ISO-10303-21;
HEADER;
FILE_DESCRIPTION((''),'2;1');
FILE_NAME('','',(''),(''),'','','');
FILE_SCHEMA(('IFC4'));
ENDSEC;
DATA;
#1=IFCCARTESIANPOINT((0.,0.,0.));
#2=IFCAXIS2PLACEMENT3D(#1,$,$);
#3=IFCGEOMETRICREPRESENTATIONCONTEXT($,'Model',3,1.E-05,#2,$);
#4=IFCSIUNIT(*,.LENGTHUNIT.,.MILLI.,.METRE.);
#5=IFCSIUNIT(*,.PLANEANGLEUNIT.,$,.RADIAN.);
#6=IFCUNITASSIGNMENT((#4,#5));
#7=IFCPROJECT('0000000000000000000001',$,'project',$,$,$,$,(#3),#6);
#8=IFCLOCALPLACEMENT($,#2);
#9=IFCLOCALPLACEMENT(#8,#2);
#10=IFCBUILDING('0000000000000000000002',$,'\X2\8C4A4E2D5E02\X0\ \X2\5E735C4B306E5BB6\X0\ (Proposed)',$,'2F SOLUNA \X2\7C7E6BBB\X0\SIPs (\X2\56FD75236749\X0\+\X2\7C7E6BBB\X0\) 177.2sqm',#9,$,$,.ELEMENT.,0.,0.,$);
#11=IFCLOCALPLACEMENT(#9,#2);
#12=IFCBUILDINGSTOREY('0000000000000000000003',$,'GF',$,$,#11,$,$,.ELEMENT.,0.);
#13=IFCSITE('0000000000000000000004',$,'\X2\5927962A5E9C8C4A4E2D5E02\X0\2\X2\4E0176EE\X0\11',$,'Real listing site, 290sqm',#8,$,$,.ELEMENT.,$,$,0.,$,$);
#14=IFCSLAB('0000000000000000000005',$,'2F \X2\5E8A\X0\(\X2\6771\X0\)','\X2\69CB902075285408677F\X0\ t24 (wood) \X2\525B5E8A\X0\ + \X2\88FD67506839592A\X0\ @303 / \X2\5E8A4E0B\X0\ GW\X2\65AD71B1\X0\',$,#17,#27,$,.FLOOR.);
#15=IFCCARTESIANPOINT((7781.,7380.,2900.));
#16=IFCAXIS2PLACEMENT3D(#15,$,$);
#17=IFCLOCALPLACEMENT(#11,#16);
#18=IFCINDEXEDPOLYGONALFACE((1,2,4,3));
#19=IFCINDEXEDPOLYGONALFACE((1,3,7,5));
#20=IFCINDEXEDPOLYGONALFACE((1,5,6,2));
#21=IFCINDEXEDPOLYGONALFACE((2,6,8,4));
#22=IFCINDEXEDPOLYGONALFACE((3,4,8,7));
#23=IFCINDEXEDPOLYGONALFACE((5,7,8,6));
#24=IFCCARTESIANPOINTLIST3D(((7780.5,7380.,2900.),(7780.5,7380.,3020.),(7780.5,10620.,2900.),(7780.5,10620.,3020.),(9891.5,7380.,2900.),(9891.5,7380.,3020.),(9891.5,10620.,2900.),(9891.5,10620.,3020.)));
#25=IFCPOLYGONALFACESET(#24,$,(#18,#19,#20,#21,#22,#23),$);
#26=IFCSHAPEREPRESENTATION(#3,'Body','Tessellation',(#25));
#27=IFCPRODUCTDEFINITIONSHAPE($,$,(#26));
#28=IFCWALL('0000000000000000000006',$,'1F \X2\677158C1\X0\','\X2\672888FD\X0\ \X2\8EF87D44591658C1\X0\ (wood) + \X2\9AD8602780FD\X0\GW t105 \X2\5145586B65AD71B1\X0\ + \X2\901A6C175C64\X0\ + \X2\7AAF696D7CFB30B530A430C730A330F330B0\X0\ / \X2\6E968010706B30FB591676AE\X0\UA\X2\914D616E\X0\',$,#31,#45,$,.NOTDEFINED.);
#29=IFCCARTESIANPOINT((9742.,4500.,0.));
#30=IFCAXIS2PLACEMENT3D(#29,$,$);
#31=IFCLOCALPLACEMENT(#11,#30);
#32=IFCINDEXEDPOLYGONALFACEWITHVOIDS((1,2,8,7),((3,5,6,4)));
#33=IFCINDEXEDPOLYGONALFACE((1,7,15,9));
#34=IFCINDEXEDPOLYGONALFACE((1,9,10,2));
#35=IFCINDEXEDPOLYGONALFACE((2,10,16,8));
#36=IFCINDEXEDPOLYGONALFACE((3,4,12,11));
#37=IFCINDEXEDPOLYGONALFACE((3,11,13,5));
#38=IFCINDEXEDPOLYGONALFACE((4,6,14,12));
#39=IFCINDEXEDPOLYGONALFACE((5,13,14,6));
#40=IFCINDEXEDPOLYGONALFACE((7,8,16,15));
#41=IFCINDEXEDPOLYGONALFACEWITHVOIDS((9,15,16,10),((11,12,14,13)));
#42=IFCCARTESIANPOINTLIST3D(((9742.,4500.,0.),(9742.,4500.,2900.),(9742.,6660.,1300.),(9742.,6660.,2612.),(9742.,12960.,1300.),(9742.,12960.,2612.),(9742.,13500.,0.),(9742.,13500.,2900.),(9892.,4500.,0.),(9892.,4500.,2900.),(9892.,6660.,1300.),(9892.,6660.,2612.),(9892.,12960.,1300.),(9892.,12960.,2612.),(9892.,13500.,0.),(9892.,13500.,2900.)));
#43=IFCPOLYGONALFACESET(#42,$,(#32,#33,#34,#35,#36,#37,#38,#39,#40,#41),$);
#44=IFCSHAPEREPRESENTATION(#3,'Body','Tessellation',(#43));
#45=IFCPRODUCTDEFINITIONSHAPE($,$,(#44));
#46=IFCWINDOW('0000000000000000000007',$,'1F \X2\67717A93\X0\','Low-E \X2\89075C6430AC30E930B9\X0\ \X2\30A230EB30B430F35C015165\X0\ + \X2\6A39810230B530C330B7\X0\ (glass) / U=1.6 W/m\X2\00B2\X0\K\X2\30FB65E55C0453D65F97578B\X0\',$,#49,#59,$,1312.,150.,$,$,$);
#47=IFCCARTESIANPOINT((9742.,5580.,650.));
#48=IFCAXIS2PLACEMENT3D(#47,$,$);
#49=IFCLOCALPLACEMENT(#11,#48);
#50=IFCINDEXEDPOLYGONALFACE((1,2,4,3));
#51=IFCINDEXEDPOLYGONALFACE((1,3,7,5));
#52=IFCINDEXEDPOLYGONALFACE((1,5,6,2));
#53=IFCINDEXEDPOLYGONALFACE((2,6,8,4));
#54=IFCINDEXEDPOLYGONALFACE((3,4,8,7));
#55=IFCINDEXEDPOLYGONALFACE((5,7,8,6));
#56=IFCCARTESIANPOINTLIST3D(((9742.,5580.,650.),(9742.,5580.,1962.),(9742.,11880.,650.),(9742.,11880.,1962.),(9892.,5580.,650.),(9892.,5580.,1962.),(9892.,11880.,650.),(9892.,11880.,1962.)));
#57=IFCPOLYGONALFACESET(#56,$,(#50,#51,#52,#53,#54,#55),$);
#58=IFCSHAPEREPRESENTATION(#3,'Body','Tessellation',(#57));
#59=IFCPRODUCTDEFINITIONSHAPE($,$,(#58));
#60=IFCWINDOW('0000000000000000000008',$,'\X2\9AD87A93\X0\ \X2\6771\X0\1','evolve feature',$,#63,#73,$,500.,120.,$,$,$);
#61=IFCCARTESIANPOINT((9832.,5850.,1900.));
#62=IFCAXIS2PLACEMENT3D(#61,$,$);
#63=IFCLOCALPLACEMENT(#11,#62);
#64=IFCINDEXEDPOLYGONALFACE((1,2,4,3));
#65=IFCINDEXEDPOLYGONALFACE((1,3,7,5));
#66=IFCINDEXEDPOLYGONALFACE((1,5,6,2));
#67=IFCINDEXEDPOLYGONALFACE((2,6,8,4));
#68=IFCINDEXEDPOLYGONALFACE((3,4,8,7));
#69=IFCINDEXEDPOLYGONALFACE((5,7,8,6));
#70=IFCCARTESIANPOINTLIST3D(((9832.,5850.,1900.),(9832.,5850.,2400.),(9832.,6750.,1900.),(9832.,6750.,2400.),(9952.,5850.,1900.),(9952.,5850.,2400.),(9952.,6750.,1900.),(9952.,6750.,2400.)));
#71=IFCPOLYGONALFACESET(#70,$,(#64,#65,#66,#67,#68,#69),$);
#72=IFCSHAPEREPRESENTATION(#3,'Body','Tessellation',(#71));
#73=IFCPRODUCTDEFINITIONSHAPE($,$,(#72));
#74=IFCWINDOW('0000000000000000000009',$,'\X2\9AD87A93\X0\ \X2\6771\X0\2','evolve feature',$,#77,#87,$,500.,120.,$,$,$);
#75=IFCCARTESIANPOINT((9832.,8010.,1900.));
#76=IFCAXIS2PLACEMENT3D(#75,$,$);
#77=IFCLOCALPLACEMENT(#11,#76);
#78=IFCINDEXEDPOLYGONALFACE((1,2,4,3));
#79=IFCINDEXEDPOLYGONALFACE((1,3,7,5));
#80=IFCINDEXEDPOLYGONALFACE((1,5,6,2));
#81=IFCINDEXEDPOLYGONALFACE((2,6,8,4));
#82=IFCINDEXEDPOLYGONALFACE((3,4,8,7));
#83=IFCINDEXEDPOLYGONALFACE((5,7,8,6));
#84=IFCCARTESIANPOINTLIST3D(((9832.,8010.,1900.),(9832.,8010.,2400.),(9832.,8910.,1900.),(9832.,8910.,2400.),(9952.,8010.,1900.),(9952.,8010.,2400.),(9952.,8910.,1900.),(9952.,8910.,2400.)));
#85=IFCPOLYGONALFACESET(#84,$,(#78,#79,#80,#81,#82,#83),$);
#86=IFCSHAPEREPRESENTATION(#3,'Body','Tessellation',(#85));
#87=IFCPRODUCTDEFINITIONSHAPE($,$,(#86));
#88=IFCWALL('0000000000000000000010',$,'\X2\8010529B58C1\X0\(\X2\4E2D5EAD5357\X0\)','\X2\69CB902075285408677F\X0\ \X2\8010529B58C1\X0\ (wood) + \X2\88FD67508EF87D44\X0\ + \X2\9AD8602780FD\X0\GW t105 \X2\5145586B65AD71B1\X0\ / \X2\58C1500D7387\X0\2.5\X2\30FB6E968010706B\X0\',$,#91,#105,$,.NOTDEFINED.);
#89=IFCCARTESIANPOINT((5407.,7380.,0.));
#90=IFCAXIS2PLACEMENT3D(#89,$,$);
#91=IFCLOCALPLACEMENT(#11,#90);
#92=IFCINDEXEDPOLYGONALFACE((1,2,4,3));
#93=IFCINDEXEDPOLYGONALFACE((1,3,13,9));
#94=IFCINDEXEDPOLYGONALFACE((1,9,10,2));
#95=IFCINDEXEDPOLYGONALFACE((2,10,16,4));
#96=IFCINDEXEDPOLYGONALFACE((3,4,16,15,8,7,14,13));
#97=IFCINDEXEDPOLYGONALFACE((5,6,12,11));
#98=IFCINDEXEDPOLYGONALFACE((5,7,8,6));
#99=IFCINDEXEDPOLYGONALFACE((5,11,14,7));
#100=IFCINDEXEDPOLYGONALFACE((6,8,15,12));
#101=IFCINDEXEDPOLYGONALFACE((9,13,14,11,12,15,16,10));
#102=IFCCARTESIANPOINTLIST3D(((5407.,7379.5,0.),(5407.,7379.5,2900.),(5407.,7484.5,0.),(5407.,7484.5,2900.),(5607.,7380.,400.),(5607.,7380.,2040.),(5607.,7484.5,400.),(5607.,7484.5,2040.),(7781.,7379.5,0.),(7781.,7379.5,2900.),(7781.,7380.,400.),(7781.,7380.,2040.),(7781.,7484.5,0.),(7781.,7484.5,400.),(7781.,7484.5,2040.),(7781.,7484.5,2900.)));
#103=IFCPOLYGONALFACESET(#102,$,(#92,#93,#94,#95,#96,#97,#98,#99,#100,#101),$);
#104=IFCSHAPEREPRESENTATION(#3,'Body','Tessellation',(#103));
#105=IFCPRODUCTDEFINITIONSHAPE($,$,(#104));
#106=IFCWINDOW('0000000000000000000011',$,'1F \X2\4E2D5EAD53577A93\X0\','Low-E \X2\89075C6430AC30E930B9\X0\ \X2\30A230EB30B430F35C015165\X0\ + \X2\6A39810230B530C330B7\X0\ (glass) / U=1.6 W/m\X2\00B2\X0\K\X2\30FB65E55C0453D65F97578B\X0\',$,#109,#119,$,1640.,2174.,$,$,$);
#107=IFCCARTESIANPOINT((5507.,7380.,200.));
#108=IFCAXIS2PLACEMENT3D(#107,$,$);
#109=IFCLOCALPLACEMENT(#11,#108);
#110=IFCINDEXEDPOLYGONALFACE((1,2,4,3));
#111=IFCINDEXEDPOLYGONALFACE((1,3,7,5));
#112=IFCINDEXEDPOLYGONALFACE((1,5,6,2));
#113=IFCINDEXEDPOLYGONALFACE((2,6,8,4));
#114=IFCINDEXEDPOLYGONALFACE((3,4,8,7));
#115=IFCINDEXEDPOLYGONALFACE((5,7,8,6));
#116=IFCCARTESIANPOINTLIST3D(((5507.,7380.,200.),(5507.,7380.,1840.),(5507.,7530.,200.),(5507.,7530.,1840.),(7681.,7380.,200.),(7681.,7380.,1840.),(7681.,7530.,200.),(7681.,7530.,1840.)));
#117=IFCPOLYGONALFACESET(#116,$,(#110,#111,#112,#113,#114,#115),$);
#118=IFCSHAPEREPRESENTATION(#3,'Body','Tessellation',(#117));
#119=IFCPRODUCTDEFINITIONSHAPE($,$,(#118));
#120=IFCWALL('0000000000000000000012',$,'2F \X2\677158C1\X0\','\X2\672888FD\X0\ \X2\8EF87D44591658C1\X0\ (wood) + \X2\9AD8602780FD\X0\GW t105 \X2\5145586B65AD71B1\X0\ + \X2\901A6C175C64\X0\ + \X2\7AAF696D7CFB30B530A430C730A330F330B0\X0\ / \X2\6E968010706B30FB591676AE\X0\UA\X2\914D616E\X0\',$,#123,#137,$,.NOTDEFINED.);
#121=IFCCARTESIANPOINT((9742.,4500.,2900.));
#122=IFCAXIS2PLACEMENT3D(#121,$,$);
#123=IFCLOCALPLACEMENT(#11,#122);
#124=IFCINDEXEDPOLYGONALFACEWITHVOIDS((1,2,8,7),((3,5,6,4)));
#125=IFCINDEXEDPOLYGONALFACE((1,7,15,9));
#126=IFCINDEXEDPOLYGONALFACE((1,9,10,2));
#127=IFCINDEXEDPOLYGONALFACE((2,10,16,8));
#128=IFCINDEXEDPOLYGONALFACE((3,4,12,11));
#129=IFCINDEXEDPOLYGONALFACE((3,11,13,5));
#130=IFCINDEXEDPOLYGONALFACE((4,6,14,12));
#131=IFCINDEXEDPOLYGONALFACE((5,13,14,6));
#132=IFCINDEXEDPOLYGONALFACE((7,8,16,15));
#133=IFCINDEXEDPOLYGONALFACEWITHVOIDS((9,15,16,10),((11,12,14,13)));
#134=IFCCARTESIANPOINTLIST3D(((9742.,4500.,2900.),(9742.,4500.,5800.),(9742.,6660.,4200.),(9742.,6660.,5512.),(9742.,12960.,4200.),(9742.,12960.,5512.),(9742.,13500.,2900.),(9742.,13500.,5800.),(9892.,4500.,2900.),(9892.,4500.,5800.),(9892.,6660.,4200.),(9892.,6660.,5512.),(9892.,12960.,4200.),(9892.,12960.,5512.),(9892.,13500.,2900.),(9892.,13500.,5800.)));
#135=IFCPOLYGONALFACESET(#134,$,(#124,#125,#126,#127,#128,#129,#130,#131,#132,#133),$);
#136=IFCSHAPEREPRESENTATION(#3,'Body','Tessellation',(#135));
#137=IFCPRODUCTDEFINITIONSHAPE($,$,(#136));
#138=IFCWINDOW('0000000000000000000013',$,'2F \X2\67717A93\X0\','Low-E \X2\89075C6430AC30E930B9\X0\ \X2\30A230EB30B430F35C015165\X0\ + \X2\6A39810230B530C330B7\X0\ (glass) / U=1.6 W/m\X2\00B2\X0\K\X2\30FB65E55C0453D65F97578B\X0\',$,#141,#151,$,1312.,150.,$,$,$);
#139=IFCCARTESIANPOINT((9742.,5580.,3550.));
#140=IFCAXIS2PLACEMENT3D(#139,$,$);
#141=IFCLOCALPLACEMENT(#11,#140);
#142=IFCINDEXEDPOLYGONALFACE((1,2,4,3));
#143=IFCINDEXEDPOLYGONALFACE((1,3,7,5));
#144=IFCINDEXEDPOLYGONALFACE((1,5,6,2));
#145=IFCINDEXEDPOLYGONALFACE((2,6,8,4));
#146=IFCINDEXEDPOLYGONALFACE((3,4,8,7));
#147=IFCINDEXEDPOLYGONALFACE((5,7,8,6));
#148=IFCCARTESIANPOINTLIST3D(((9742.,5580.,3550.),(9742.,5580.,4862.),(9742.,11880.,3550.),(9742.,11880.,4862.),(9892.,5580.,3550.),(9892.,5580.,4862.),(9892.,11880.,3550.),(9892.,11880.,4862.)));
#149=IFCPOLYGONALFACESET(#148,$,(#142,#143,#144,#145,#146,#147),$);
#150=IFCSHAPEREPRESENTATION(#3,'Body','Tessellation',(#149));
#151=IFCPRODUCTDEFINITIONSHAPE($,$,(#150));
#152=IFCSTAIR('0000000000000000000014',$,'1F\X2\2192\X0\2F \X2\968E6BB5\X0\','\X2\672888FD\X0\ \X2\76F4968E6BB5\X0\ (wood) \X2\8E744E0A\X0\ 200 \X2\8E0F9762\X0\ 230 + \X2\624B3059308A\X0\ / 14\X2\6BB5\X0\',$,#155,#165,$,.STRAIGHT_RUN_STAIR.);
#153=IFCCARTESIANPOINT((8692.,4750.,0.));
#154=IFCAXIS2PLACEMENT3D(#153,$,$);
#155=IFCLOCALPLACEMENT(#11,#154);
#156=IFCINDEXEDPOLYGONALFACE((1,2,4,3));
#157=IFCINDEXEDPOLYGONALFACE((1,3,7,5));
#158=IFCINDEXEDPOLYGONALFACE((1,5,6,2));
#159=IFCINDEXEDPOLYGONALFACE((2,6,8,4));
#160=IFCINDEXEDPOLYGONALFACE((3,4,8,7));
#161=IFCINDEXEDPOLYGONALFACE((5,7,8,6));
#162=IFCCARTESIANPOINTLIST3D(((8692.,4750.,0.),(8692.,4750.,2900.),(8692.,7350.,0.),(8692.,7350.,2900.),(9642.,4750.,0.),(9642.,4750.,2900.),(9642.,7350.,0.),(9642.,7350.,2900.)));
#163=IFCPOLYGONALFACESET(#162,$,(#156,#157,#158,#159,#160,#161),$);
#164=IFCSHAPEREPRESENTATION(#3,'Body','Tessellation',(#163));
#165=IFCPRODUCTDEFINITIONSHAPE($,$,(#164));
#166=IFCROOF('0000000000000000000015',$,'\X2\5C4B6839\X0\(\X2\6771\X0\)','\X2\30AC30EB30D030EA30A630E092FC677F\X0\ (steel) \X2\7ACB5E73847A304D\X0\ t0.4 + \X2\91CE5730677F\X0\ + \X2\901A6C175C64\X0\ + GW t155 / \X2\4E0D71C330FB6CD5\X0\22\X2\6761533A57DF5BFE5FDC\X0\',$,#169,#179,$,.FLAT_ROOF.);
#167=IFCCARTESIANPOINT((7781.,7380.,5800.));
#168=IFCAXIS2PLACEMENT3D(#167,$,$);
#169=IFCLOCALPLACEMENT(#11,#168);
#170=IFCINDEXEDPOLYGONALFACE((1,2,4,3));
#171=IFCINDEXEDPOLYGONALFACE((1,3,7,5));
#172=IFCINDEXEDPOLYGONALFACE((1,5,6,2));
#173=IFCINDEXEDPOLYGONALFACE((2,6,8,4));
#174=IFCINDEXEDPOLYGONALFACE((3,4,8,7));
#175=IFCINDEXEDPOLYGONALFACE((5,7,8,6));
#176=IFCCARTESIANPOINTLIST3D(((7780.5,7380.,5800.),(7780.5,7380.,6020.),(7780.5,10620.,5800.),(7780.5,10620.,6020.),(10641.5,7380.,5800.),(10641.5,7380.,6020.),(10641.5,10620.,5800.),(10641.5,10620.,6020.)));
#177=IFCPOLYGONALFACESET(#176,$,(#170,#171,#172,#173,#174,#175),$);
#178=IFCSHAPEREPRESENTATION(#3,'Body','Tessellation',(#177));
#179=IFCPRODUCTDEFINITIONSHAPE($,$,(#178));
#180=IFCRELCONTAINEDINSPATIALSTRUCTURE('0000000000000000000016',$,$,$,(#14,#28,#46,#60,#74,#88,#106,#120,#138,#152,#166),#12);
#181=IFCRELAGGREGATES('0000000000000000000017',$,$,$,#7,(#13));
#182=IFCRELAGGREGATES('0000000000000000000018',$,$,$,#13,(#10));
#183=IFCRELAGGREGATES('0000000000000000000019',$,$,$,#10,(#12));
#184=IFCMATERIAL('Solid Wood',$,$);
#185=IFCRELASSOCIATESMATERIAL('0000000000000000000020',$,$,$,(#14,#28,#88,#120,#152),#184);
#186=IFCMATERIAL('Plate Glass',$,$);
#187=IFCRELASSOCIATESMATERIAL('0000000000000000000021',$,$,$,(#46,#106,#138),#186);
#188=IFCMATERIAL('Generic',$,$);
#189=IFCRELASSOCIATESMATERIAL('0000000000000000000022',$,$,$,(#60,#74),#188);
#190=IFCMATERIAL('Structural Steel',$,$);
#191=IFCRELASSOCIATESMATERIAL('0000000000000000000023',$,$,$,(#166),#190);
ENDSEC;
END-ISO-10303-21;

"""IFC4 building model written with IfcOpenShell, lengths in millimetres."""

from ifc_helpers import new_model, si_unit, frame, frame_2d, origin, place, context, project, spatial, rectangle, extrude, material, element, fill, save


model = new_model("IFC4")

# Units and contexts
model_context = context("Model", 3, precision=1e-05, world=origin())
ifc_project = project(units=[si_unit("LENGTHUNIT", "METRE", prefix="MILLI"), si_unit("PLANEANGLEUNIT", "RADIAN")], contexts=[model_context])

# Site, building, storey
site_placement = place(None, origin())
site = spatial("IfcSite", under=ifc_project, at=site_placement, Name="大阪府豊中市2丁目11", ObjectType="Real listing site, 290sqm", CompositionType="ELEMENT", RefElevation=0.0)
building_placement = place(site_placement, origin())
building = spatial("IfcBuilding", under=site, at=building_placement, Name="豊中市 平屋の家 (Proposed)", ObjectType="2F SOLUNA 籾殻SIPs (国産杉+籾殻) 177.2sqm", CompositionType="ELEMENT", ElevationOfRefHeight=0.0, ElevationOfTerrain=0.0)
storey_placement = place(building_placement, origin())
storey = spatial("IfcBuildingStorey", under=building, at=storey_placement, Name="GF", CompositionType="ELEMENT", Elevation=0.0)

# Slab
ifc_material_1 = material(Name="Solid Wood")
slab_1_placement = place(storey_placement, frame((7781.0, 7380.0, 2900.0)))
element("IfcSlab", 1, at=slab_1_placement, inside=storey, material=ifc_material_1, Name="2F 床(東)", Description="構造用合板 t24 (wood) 剛床 + 製材根太 @303 / 床下 GW断熱", PredefinedType="FLOOR", context=model_context, shape_type="SweptSolid", body=[
    extrude(rectangle(XDim=2111.0, YDim=3240.0, at=frame_2d((1055.0, 1620.0))), frame((7781.0, 7380.0, 2900.0)), (0.0, 0.0, 1.0), 120.0),
])

# Wall, openings, windows
wall_1_placement = place(storey_placement, frame((9742.0, 4500.0, 0.0)))
wall_1 = element("IfcWall", 2, at=wall_1_placement, inside=storey, material=ifc_material_1, Name="1F 東壁", Description="木製 軸組外壁 (wood) + 高性能GW t105 充填断熱 + 通気層 + 窯業系サイディング / 準耐火・外皮UA配慮", PredefinedType="NOTDEFINED", context=model_context, shape_type="SweptSolid", body=[
    extrude(rectangle(XDim=150.0, YDim=9000.0, at=frame_2d((75.0, 4500.0))), frame((9742.0, 4500.0, 0.0)), (0.0, 0.0, 1.0), 2900.0),
])
opening_1_placement = place(storey_placement, frame((9742.0, 5580.0, 650.0)))
opening_1 = element("IfcOpeningElement", 3, at=opening_1_placement, cuts=wall_1, PredefinedType="NOTDEFINED", context=model_context, shape_type="SweptSolid", body=[
    extrude(rectangle(XDim=150.0, YDim=6300.0, at=frame_2d((75.0, 3150.0))), frame((9742.0, 5580.0, 650.0)), (0.0, 0.0, 1.0), 1312.0),
])
opening_2_placement = place(storey_placement, frame((9832.0, 5850.0, 1900.0)))
opening_2 = element("IfcOpeningElement", 4, at=opening_2_placement, cuts=wall_1, PredefinedType="NOTDEFINED", context=model_context, shape_type="SweptSolid", body=[
    extrude(rectangle(XDim=120.0, YDim=900.0, at=frame_2d((60.0, 450.0))), frame((9832.0, 5850.0, 1900.0)), (0.0, 0.0, 1.0), 500.0),
])
opening_3_placement = place(storey_placement, frame((9832.0, 8010.0, 1900.0)))
opening_3 = element("IfcOpeningElement", 5, at=opening_3_placement, cuts=wall_1, PredefinedType="NOTDEFINED", context=model_context, shape_type="SweptSolid", body=[
    extrude(rectangle(XDim=120.0, YDim=900.0, at=frame_2d((60.0, 450.0))), frame((9832.0, 8010.0, 1900.0)), (0.0, 0.0, 1.0), 500.0),
])
ifc_material_2 = material(Name="Plate Glass")
window_1_placement = place(storey_placement, frame((9742.0, 5580.0, 650.0)))
window_1 = element("IfcWindow", 6, at=window_1_placement, inside=storey, material=ifc_material_2, Name="1F 東窓", Description="Low-E 複層ガラス アルゴン封入 + 樹脂サッシ (glass) / U=1.6 W/m²K・日射取得型", OverallHeight=1312.0, OverallWidth=150.0, context=model_context, shape_type="SweptSolid", body=[
    extrude(rectangle(XDim=150.0, YDim=6300.0, at=frame_2d((75.0, 3150.0))), frame((9742.0, 5580.0, 650.0)), (0.0, 0.0, 1.0), 1312.0),
])
fill(opening_1, window_1)
ifc_material_3 = material(Name="Generic")
window_2_placement = place(storey_placement, frame((9832.0, 5850.0, 1900.0)))
window_2 = element("IfcWindow", 7, at=window_2_placement, inside=storey, material=ifc_material_3, Name="高窓 東1", Description="evolve feature", OverallHeight=500.0, OverallWidth=120.0, context=model_context, shape_type="SweptSolid", body=[
    extrude(rectangle(XDim=120.0, YDim=900.0, at=frame_2d((60.0, 450.0))), frame((9832.0, 5850.0, 1900.0)), (0.0, 0.0, 1.0), 500.0),
])
fill(opening_2, window_2)
window_3_placement = place(storey_placement, frame((9832.0, 8010.0, 1900.0)))
window_3 = element("IfcWindow", 8, at=window_3_placement, inside=storey, material=ifc_material_3, Name="高窓 東2", Description="evolve feature", OverallHeight=500.0, OverallWidth=120.0, context=model_context, shape_type="SweptSolid", body=[
    extrude(rectangle(XDim=120.0, YDim=900.0, at=frame_2d((60.0, 450.0))), frame((9832.0, 8010.0, 1900.0)), (0.0, 0.0, 1.0), 500.0),
])
fill(opening_3, window_3)

# Wall, opening, window
wall_2_placement = place(storey_placement, frame((5407.0, 7380.0, 0.0)))
wall_2 = element("IfcWall", 9, at=wall_2_placement, inside=storey, material=ifc_material_1, Name="耐力壁(中庭南)", Description="構造用合板 耐力壁 (wood) + 製材軸組 + 高性能GW t105 充填断熱 / 壁倍率2.5・準耐火", PredefinedType="NOTDEFINED", context=model_context, shape_type="SweptSolid", body=[
    extrude(rectangle(XDim=2374.0, YDim=105.0, at=frame_2d((1187.0, 52.0))), frame((5407.0, 7380.0, 0.0)), (0.0, 0.0, 1.0), 2900.0),
])
opening_4_placement = place(storey_placement, frame((5507.0, 7380.0, 200.0)))
opening_4 = element("IfcOpeningElement", 10, at=opening_4_placement, cuts=wall_2, PredefinedType="NOTDEFINED", context=model_context, shape_type="SweptSolid", body=[
    extrude(rectangle(XDim=2174.0, YDim=150.0, at=frame_2d((1087.0, 75.0))), frame((5507.0, 7380.0, 200.0)), (0.0, 0.0, 1.0), 1640.0),
])
window_4_placement = place(storey_placement, frame((5507.0, 7380.0, 200.0)))
window_4 = element("IfcWindow", 11, at=window_4_placement, inside=storey, material=ifc_material_2, Name="1F 中庭南窓", Description="Low-E 複層ガラス アルゴン封入 + 樹脂サッシ (glass) / U=1.6 W/m²K・日射取得型", OverallHeight=1640.0, OverallWidth=2174.0, context=model_context, shape_type="SweptSolid", body=[
    extrude(rectangle(XDim=2174.0, YDim=150.0, at=frame_2d((1087.0, 75.0))), frame((5507.0, 7380.0, 200.0)), (0.0, 0.0, 1.0), 1640.0),
])
fill(opening_4, window_4)

# Wall, opening, window
wall_3_placement = place(storey_placement, frame((9742.0, 4500.0, 2900.0)))
wall_3 = element("IfcWall", 12, at=wall_3_placement, inside=storey, material=ifc_material_1, Name="2F 東壁", Description="木製 軸組外壁 (wood) + 高性能GW t105 充填断熱 + 通気層 + 窯業系サイディング / 準耐火・外皮UA配慮", PredefinedType="NOTDEFINED", context=model_context, shape_type="SweptSolid", body=[
    extrude(rectangle(XDim=150.0, YDim=9000.0, at=frame_2d((75.0, 4500.0))), frame((9742.0, 4500.0, 2900.0)), (0.0, 0.0, 1.0), 2900.0),
])
opening_5_placement = place(storey_placement, frame((9742.0, 5580.0, 3550.0)))
opening_5 = element("IfcOpeningElement", 13, at=opening_5_placement, cuts=wall_3, PredefinedType="NOTDEFINED", context=model_context, shape_type="SweptSolid", body=[
    extrude(rectangle(XDim=150.0, YDim=6300.0, at=frame_2d((75.0, 3150.0))), frame((9742.0, 5580.0, 3550.0)), (0.0, 0.0, 1.0), 1312.0),
])
window_5_placement = place(storey_placement, frame((9742.0, 5580.0, 3550.0)))
window_5 = element("IfcWindow", 14, at=window_5_placement, inside=storey, material=ifc_material_2, Name="2F 東窓", Description="Low-E 複層ガラス アルゴン封入 + 樹脂サッシ (glass) / U=1.6 W/m²K・日射取得型", OverallHeight=1312.0, OverallWidth=150.0, context=model_context, shape_type="SweptSolid", body=[
    extrude(rectangle(XDim=150.0, YDim=6300.0, at=frame_2d((75.0, 3150.0))), frame((9742.0, 5580.0, 3550.0)), (0.0, 0.0, 1.0), 1312.0),
])
fill(opening_5, window_5)

# Stair
stair_placement = place(storey_placement, frame((8692.0, 4750.0, 0.0)))
element("IfcStair", 15, at=stair_placement, inside=storey, material=ifc_material_1, Name="1F→2F 階段", Description="木製 直階段 (wood) 蹴上 200 踏面 230 + 手すり / 14段", PredefinedType="STRAIGHT_RUN_STAIR", context=model_context, shape_type="SweptSolid", body=[
    extrude(rectangle(XDim=950.0, YDim=2600.0, at=frame_2d((475.0, 1300.0))), frame((8692.0, 4750.0, 0.0)), (0.0, 0.0, 1.0), 2900.0),
])

# Roof
ifc_material_4 = material(Name="Structural Steel")
roof_placement = place(storey_placement, frame((7781.0, 7380.0, 5800.0)))
element("IfcRoof", 16, at=roof_placement, inside=storey, material=ifc_material_4, Name="屋根(東)", Description="ガルバリウム鋼板 (steel) 立平葺き t0.4 + 野地板 + 通気層 + GW t155 / 不燃・法22条区域対応", PredefinedType="FLAT_ROOF", context=model_context, shape_type="SweptSolid", body=[
    extrude(rectangle(XDim=2861.0, YDim=3240.0, at=frame_2d((1430.0, 1620.0))), frame((7781.0, 7380.0, 5800.0)), (0.0, 0.0, 1.0), 220.0),
])

save(model, "model.ifc")
